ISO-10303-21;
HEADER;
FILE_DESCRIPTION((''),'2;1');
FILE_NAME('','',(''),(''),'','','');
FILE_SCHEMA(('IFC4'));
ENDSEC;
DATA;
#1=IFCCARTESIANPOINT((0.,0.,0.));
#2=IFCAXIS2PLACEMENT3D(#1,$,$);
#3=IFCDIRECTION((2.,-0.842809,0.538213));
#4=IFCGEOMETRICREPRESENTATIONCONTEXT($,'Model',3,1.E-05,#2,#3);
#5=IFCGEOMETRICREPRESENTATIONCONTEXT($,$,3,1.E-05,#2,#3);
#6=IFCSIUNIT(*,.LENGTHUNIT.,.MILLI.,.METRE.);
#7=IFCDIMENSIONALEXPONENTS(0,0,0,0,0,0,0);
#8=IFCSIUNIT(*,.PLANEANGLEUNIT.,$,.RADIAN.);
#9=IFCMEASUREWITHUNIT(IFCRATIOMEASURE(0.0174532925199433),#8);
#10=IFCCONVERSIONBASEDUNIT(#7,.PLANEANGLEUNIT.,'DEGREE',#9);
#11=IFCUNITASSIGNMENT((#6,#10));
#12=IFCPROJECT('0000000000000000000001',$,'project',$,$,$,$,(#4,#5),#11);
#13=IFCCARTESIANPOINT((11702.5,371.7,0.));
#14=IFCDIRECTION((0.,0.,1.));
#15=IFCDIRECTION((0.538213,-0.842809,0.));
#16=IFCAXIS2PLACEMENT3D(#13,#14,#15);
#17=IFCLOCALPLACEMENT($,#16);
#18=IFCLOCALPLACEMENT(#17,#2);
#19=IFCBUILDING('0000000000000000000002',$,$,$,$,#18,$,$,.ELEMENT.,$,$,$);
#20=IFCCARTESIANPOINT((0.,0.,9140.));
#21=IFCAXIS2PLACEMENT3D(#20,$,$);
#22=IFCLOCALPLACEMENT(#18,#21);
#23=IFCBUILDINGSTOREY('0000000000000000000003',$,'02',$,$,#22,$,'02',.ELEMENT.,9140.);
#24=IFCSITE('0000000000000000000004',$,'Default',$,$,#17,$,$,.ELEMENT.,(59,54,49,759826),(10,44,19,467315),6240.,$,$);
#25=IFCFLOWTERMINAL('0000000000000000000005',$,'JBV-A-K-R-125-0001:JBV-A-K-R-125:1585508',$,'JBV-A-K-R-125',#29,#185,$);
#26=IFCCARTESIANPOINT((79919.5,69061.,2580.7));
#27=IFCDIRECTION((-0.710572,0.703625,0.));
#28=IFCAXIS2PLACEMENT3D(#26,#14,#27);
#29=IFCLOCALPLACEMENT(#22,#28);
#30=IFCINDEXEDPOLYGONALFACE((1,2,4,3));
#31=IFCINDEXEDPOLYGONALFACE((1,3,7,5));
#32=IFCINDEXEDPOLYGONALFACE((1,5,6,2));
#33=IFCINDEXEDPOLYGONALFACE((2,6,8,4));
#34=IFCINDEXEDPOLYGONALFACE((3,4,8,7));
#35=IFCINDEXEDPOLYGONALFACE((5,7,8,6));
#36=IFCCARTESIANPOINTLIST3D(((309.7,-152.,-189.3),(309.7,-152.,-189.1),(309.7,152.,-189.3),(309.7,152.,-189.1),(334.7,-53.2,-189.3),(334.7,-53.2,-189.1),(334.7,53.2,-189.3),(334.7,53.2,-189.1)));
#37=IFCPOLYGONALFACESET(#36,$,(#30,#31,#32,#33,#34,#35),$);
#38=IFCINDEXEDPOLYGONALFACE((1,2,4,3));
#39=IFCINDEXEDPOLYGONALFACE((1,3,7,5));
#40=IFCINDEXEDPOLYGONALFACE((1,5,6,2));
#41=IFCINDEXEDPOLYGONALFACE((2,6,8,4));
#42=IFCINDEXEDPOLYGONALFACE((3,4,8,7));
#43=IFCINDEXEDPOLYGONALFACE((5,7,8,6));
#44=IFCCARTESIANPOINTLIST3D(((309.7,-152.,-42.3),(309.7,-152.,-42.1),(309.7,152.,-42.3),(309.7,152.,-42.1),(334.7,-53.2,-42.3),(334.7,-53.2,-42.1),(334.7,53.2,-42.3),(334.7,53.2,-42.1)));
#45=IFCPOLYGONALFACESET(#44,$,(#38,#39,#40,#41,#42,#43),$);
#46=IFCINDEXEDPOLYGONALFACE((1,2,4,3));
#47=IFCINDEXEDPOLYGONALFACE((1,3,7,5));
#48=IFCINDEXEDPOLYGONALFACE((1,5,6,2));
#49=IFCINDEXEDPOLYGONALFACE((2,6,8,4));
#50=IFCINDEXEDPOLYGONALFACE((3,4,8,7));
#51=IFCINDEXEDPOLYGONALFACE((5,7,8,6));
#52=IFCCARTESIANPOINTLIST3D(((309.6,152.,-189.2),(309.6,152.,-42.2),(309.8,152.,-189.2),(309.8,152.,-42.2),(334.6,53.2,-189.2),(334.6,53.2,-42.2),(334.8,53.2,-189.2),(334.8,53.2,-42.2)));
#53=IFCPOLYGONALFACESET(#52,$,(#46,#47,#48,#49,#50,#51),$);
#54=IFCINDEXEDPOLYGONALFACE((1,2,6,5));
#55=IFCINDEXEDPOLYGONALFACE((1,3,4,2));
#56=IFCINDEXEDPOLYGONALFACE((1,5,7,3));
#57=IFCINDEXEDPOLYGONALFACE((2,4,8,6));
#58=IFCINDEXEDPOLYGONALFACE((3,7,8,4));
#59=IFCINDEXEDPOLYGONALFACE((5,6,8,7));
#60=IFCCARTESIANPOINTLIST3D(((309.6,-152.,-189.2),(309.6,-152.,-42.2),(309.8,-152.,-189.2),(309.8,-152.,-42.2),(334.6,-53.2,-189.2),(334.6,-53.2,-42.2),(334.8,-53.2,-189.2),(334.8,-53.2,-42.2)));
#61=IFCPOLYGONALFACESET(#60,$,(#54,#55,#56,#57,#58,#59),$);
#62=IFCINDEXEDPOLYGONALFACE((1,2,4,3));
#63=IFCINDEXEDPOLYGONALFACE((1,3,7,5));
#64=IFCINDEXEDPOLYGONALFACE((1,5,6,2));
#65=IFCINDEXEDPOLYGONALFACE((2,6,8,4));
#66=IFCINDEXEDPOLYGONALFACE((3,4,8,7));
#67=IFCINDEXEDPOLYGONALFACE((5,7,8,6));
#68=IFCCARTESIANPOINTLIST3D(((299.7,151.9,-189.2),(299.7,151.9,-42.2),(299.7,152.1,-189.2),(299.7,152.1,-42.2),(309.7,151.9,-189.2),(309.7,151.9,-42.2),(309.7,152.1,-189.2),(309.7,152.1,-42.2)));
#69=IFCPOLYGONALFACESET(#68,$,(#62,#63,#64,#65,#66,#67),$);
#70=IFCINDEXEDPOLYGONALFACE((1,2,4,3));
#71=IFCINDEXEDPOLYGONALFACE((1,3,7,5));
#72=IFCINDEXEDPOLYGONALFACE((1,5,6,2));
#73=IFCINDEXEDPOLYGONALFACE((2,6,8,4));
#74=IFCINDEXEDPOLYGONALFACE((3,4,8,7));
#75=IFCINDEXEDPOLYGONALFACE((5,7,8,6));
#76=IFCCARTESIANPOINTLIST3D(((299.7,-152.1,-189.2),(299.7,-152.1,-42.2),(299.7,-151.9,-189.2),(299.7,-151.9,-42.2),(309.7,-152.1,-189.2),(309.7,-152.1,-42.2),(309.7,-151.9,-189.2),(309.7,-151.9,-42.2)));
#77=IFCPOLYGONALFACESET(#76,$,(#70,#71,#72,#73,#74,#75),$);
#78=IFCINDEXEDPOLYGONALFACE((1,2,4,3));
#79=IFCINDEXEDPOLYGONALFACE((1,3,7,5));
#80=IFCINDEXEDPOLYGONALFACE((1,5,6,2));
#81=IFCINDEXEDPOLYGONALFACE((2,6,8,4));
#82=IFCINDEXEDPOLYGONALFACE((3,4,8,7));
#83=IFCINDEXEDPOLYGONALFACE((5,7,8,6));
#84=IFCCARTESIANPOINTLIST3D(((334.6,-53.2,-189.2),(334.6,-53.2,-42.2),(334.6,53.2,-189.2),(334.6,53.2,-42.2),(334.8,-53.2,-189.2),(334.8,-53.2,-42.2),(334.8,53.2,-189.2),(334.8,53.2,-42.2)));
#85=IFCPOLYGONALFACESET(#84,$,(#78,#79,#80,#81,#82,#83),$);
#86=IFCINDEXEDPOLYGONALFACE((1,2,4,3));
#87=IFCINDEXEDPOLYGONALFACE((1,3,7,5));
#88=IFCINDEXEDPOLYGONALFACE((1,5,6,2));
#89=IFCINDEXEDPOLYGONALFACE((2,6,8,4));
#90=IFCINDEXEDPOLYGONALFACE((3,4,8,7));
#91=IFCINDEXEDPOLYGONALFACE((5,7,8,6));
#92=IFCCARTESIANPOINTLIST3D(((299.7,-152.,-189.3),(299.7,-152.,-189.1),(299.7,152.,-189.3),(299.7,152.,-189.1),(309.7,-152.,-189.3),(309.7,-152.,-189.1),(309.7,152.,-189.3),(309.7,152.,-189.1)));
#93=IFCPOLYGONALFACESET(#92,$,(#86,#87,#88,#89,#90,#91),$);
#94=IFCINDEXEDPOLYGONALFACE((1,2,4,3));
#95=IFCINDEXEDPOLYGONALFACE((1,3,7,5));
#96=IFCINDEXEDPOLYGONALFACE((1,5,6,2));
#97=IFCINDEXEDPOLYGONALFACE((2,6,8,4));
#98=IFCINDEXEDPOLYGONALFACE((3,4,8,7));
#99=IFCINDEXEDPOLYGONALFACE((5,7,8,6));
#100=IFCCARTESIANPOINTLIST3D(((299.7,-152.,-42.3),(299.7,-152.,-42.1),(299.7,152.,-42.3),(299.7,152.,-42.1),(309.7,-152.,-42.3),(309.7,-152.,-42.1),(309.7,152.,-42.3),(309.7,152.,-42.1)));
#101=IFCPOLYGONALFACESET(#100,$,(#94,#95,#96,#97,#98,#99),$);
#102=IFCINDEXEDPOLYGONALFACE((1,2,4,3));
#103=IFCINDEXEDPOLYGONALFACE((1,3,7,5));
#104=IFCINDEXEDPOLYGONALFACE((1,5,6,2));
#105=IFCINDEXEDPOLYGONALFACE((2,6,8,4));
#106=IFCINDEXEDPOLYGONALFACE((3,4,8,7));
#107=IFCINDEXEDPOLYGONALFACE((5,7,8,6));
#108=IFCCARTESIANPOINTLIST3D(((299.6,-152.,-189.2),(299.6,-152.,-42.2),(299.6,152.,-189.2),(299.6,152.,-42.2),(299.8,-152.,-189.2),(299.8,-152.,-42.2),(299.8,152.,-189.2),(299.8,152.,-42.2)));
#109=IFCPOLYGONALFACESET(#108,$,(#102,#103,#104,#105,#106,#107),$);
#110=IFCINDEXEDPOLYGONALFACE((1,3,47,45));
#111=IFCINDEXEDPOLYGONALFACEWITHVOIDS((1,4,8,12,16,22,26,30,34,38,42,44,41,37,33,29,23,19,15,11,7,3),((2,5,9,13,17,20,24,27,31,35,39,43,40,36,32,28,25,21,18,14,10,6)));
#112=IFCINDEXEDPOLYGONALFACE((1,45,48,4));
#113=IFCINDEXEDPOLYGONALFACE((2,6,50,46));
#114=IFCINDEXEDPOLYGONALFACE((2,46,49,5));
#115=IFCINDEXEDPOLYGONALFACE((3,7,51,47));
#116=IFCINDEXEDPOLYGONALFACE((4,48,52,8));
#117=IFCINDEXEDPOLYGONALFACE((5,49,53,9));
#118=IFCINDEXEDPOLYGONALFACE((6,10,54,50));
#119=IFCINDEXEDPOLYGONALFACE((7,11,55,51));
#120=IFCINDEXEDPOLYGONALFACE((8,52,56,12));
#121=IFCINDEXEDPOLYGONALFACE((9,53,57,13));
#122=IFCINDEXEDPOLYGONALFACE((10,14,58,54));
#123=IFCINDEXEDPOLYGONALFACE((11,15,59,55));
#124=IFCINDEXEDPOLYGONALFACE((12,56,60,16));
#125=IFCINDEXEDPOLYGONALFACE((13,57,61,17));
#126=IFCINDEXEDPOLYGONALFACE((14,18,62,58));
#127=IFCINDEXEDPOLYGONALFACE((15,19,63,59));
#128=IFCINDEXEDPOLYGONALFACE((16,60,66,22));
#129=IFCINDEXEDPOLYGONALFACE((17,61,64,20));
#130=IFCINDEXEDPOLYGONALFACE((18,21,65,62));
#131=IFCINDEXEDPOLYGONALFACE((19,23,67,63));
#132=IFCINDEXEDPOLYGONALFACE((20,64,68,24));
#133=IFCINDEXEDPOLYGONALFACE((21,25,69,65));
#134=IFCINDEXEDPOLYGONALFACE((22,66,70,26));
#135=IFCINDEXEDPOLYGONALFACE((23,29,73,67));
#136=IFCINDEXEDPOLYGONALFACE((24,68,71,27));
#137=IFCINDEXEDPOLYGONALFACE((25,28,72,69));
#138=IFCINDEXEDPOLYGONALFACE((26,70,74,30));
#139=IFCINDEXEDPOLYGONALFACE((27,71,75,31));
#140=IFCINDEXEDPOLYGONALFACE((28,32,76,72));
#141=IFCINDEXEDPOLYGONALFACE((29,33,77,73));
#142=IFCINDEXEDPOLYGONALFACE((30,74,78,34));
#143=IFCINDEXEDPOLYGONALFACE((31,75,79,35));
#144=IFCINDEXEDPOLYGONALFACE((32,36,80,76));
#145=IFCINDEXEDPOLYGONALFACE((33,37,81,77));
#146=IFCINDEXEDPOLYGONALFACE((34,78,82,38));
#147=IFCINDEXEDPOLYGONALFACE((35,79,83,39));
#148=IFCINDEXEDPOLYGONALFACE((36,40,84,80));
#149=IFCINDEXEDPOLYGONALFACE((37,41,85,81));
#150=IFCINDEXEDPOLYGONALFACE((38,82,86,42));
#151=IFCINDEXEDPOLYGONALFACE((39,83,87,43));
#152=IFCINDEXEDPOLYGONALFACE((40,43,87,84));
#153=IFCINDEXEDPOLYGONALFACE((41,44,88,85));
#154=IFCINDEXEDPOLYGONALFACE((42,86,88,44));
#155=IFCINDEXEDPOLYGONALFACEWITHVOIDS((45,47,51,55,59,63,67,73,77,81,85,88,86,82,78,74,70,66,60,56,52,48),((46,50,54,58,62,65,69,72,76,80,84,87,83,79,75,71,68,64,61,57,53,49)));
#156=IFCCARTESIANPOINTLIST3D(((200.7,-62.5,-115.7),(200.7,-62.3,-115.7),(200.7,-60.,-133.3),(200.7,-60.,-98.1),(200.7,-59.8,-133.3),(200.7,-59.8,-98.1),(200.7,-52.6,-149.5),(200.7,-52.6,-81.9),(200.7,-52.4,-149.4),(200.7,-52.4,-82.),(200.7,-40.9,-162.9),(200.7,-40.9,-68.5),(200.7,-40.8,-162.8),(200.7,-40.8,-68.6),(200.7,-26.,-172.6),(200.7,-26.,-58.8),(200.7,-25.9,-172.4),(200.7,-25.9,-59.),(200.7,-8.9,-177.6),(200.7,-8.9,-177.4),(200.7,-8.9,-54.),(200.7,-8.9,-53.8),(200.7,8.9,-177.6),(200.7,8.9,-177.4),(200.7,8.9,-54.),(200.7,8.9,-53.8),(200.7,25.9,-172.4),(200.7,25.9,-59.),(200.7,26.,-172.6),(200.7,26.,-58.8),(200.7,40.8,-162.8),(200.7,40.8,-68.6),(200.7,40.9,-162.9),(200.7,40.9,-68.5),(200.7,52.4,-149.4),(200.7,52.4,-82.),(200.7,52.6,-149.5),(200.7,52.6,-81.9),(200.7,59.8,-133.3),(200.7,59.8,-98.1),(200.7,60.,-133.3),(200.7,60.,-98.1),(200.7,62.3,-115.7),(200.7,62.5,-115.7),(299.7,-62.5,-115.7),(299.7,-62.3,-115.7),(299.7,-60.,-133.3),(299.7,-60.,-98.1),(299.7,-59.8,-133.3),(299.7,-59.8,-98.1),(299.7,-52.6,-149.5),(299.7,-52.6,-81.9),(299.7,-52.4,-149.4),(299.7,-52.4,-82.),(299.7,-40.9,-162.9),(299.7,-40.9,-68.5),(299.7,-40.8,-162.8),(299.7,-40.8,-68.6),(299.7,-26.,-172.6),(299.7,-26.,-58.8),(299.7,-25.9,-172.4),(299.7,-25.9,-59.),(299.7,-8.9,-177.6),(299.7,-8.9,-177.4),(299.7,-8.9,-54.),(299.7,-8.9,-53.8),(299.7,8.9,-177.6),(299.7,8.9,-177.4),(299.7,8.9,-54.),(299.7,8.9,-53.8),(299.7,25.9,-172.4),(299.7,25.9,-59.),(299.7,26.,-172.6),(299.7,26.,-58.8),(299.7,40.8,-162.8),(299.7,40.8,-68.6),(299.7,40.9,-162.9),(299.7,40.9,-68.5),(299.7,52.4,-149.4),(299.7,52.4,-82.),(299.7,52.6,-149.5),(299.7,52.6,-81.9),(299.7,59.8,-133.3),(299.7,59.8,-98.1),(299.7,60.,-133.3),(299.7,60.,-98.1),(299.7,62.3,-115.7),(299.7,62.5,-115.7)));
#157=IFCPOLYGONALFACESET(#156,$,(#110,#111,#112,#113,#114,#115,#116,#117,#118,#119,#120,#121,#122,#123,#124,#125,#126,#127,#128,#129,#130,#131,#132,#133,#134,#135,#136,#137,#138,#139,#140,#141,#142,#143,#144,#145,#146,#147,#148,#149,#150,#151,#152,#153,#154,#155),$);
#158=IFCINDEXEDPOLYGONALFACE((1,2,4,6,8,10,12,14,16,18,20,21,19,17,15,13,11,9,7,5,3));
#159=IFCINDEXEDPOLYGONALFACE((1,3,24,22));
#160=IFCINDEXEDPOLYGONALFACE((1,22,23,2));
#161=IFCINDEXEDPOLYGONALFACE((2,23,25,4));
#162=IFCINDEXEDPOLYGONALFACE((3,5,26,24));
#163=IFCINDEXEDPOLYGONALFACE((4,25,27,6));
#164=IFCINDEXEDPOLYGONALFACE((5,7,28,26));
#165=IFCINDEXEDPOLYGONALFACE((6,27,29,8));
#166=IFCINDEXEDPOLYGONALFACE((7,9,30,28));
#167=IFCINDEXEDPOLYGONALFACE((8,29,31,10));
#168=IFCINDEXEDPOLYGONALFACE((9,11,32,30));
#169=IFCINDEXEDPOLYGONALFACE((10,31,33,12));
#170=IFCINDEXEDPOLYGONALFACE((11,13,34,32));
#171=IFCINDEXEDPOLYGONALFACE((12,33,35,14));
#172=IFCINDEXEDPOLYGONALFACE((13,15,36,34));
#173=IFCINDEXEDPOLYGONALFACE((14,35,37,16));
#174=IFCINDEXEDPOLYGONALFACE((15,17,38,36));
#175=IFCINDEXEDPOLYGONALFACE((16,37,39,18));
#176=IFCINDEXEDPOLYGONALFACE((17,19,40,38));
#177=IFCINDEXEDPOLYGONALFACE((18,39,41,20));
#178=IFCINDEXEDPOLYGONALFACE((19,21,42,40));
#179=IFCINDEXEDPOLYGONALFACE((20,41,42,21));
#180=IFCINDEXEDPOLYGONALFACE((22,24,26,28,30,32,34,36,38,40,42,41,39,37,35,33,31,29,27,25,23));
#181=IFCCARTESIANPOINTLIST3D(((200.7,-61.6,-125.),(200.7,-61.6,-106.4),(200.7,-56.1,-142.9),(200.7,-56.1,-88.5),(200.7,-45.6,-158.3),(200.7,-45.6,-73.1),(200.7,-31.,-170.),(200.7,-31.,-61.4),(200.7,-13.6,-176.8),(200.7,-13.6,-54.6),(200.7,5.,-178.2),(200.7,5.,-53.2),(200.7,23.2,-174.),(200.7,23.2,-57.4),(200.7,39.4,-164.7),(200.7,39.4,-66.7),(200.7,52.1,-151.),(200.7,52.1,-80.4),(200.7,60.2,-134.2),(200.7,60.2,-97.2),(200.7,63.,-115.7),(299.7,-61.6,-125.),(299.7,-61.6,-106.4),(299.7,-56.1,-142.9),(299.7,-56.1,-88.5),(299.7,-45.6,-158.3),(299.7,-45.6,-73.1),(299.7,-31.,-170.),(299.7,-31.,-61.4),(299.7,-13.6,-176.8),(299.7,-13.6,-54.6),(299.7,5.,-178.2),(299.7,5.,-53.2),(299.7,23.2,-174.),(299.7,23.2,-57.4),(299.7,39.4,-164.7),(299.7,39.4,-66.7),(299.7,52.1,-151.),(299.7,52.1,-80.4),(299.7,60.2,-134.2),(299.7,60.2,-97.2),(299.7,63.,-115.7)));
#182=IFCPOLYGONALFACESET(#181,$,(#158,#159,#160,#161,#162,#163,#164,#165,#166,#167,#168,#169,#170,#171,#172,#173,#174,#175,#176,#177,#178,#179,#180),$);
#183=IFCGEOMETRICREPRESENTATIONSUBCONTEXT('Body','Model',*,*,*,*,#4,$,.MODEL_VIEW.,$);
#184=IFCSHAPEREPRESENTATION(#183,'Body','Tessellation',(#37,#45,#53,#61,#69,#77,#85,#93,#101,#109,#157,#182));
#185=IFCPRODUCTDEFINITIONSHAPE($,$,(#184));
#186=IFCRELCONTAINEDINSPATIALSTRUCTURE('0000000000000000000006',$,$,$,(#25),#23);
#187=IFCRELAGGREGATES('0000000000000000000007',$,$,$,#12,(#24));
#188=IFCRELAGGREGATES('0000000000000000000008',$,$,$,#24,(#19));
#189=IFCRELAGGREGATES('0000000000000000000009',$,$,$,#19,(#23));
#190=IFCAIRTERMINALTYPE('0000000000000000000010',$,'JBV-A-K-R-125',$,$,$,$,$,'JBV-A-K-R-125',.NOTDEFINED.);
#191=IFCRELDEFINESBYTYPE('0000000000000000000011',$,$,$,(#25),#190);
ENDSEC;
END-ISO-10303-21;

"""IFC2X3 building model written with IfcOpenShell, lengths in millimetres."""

from ifc_helpers import new_model, entity, si_unit, converted_unit, direction, frame, frame_2d, origin, origin_2d_with_axis, place, context, subcontext, project, spatial, polyline, circle_curve, parameter, trimmed, segment, composite_curve, rectangle, circle, outline, extrude, source, transform, mapped, type_object, type_shapes, element, save


model = new_model("IFC2X3")

# Units and contexts
model_context = context("Model", 3, precision=1e-05, world=origin(), true_north=direction((2.0, -0.842809, 0.538213)))
context_of_model = context(None, 3, precision=1e-05, world=origin(), true_north=direction((2.0, -0.842809, 0.538213)))
body_context = subcontext(model_context, "Body", "Model", "MODEL_VIEW")
ifc_project = project(units=[si_unit("LENGTHUNIT", "METRE", prefix="MILLI"), converted_unit("PLANEANGLEUNIT", "DEGREE", entity("IfcRatioMeasure", 0.0174532925199433), si_unit("PLANEANGLEUNIT", "RADIAN"), dimensions=[0, 0, 0, 0, 0, 0, 0])], contexts=[model_context, context_of_model])

# Site, building, storey
site_placement = place(None, frame((11702.5, 371.7, 0.0), z_axis=(0.0, 0.0, 1.0), x_axis=(0.538213, -0.842809, 0.0)))
site = spatial("IfcSite", under=ifc_project, at=site_placement, Name="Default", CompositionType="ELEMENT", RefLatitude=(59, 54, 49, 759826), RefLongitude=(10, 44, 19, 467315), RefElevation=6240.0)
building_placement = place(site_placement, origin())
building = spatial("IfcBuilding", under=site, at=building_placement, CompositionType="ELEMENT")
storey_placement = place(building_placement, frame((0.0, 0.0, 9140.0)))
storey = spatial("IfcBuildingStorey", under=building, at=storey_placement, Name="02", LongName="02", CompositionType="ELEMENT", Elevation=9140.0)

# Flow terminal
air_terminal_type_1 = type_object("IfcAirTerminalType", Name="JBV-A-K-R-125", ElementType="JBV-A-K-R-125", PredefinedType="NOTDEFINED")
shared_shape_1 = source(origin(), body_context, "Body", "SweptSolid", [
    extrude(outline(polyline([(-152.0, -12.5), (152.0, -12.5), (53.2, 12.5), (-53.2, 12.5), (-152.0, -12.5)])), frame((322.2, 0.0, -189.3), z_axis=(0.0, 0.0, 1.0), x_axis=(0.0, -1.0, 0.0)), (0.0, 0.0, 1.0), 0.2),
    extrude(outline(polyline([(-152.0, -12.5), (152.0, -12.5), (53.2, 12.5), (-53.2, 12.5), (-152.0, -12.5)])), frame((322.2, 0.0, -42.3), z_axis=(0.0, 0.0, 1.0), x_axis=(0.0, -1.0, 0.0)), (0.0, 0.0, 1.0), 0.2),
    extrude(rectangle(XDim=0.2, YDim=101.9, at=frame_2d((0.0, 0.0), x_axis=(1.0, 0.0))), frame((322.2, 102.6, -189.2), z_axis=(0.0, 0.0, 1.0), x_axis=(0.969446, 0.245305, 0.0)), (0.0, 0.0, 1.0), 147.0),
    extrude(rectangle(XDim=0.2, YDim=101.9, at=frame_2d((0.0, 0.0), x_axis=(1.0, 0.0))), frame((322.2, -102.6, -189.2), z_axis=(0.0, 0.0, 1.0), x_axis=(-0.969446, 0.245305, 0.0)), (0.0, 0.0, 1.0), 147.0),
    extrude(rectangle(XDim=0.2, YDim=10.0, at=frame_2d((0.0, 0.0), x_axis=(1.0, 0.0))), frame((304.7, 152.0, -189.2), z_axis=(0.0, 0.0, 1.0), x_axis=(0.0, 1.0, 0.0)), (0.0, 0.0, 1.0), 147.0),
    extrude(rectangle(XDim=0.2, YDim=10.0, at=frame_2d((0.0, 0.0), x_axis=(1.0, 0.0))), frame((304.7, -152.0, -189.2), z_axis=(0.0, 0.0, 1.0), x_axis=(0.0, 1.0, 0.0)), (0.0, 0.0, 1.0), 147.0),
    extrude(rectangle(XDim=0.2, YDim=106.4, at=frame_2d((0.0, 0.0), x_axis=(1.0, 0.0))), frame((334.7, 0.0, -189.2)), (0.0, 0.0, 1.0), 147.0),
    extrude(rectangle(XDim=304.0, YDim=10.0, at=frame_2d((0.0, 0.0), x_axis=(1.0, 0.0))), frame((304.7, 0.0, -189.3), z_axis=(0.0, 0.0, 1.0), x_axis=(0.0, -1.0, 0.0)), (0.0, 0.0, 1.0), 0.2),
    extrude(rectangle(XDim=304.0, YDim=10.0, at=frame_2d((0.0, 0.0), x_axis=(1.0, 0.0))), frame((304.7, 0.0, -42.3), z_axis=(0.0, 0.0, 1.0), x_axis=(0.0, -1.0, 0.0)), (0.0, 0.0, 1.0), 0.2),
    extrude(rectangle(XDim=0.2, YDim=304.0, at=frame_2d((0.0, 0.0), x_axis=(1.0, 0.0))), frame((299.7, 0.0, -189.2)), (0.0, 0.0, 1.0), 147.0),
    extrude(outline(composite_curve([segment(trimmed(circle_curve(origin_2d_with_axis(), 62.5), [parameter(0.0)], [parameter(180.0)], True, "PARAMETER"), True, "CONTINUOUS"), segment(trimmed(circle_curve(origin_2d_with_axis(), 62.5), [parameter(180.0)], [parameter(360.0)], True, "PARAMETER"), True, "CONTINUOUS")], self_intersect=False), holes=[composite_curve([segment(trimmed(circle_curve(origin_2d_with_axis(), 62.3), [parameter(180.0)], [parameter(360.0)], True, "PARAMETER"), False, "CONTINUOUS"), segment(trimmed(circle_curve(origin_2d_with_axis(), 62.3), [parameter(0.0)], [parameter(180.0)], True, "PARAMETER"), False, "CONTINUOUS")], self_intersect=False)]), frame((200.7, 0.0, -115.7), z_axis=(1.0, 0.0, 0.0), x_axis=(0.0, 1.0, 0.0)), (0.0, 0.0, 1.0), 99.0),
    extrude(circle(Radius=62.6, at=frame_2d((0.0, 0.0), x_axis=(1.0, 0.0))), frame((200.7, 0.3, -115.7), z_axis=(1.0, 0.0, 0.0), x_axis=(0.0, 1.0, 0.0)), (0.0, 0.0, 1.0), 99.0),
])
type_shapes(air_terminal_type_1, [shared_shape_1])
for number, where, z_axis, x_axis, name in (
    (1, (79919.5, 69061.0, 2580.7), (0.0, 0.0, 1.0), (-0.710572, 0.703625, 0.0), "JBV-A-K-R-125-0001:JBV-A-K-R-125:1585508"),
):
    element("IfcFlowTerminal", number, at=place(storey_placement, frame(where, z_axis=z_axis, x_axis=x_axis)), inside=storey, type_object=air_terminal_type_1, Name=name, ObjectType="JBV-A-K-R-125", context=body_context, shape_type="MappedRepresentation", body=[
        mapped(shared_shape_1, transform((0.0, 0.0, 0.0), scale=1.0)),
    ])

save(model, "model.ifc")
